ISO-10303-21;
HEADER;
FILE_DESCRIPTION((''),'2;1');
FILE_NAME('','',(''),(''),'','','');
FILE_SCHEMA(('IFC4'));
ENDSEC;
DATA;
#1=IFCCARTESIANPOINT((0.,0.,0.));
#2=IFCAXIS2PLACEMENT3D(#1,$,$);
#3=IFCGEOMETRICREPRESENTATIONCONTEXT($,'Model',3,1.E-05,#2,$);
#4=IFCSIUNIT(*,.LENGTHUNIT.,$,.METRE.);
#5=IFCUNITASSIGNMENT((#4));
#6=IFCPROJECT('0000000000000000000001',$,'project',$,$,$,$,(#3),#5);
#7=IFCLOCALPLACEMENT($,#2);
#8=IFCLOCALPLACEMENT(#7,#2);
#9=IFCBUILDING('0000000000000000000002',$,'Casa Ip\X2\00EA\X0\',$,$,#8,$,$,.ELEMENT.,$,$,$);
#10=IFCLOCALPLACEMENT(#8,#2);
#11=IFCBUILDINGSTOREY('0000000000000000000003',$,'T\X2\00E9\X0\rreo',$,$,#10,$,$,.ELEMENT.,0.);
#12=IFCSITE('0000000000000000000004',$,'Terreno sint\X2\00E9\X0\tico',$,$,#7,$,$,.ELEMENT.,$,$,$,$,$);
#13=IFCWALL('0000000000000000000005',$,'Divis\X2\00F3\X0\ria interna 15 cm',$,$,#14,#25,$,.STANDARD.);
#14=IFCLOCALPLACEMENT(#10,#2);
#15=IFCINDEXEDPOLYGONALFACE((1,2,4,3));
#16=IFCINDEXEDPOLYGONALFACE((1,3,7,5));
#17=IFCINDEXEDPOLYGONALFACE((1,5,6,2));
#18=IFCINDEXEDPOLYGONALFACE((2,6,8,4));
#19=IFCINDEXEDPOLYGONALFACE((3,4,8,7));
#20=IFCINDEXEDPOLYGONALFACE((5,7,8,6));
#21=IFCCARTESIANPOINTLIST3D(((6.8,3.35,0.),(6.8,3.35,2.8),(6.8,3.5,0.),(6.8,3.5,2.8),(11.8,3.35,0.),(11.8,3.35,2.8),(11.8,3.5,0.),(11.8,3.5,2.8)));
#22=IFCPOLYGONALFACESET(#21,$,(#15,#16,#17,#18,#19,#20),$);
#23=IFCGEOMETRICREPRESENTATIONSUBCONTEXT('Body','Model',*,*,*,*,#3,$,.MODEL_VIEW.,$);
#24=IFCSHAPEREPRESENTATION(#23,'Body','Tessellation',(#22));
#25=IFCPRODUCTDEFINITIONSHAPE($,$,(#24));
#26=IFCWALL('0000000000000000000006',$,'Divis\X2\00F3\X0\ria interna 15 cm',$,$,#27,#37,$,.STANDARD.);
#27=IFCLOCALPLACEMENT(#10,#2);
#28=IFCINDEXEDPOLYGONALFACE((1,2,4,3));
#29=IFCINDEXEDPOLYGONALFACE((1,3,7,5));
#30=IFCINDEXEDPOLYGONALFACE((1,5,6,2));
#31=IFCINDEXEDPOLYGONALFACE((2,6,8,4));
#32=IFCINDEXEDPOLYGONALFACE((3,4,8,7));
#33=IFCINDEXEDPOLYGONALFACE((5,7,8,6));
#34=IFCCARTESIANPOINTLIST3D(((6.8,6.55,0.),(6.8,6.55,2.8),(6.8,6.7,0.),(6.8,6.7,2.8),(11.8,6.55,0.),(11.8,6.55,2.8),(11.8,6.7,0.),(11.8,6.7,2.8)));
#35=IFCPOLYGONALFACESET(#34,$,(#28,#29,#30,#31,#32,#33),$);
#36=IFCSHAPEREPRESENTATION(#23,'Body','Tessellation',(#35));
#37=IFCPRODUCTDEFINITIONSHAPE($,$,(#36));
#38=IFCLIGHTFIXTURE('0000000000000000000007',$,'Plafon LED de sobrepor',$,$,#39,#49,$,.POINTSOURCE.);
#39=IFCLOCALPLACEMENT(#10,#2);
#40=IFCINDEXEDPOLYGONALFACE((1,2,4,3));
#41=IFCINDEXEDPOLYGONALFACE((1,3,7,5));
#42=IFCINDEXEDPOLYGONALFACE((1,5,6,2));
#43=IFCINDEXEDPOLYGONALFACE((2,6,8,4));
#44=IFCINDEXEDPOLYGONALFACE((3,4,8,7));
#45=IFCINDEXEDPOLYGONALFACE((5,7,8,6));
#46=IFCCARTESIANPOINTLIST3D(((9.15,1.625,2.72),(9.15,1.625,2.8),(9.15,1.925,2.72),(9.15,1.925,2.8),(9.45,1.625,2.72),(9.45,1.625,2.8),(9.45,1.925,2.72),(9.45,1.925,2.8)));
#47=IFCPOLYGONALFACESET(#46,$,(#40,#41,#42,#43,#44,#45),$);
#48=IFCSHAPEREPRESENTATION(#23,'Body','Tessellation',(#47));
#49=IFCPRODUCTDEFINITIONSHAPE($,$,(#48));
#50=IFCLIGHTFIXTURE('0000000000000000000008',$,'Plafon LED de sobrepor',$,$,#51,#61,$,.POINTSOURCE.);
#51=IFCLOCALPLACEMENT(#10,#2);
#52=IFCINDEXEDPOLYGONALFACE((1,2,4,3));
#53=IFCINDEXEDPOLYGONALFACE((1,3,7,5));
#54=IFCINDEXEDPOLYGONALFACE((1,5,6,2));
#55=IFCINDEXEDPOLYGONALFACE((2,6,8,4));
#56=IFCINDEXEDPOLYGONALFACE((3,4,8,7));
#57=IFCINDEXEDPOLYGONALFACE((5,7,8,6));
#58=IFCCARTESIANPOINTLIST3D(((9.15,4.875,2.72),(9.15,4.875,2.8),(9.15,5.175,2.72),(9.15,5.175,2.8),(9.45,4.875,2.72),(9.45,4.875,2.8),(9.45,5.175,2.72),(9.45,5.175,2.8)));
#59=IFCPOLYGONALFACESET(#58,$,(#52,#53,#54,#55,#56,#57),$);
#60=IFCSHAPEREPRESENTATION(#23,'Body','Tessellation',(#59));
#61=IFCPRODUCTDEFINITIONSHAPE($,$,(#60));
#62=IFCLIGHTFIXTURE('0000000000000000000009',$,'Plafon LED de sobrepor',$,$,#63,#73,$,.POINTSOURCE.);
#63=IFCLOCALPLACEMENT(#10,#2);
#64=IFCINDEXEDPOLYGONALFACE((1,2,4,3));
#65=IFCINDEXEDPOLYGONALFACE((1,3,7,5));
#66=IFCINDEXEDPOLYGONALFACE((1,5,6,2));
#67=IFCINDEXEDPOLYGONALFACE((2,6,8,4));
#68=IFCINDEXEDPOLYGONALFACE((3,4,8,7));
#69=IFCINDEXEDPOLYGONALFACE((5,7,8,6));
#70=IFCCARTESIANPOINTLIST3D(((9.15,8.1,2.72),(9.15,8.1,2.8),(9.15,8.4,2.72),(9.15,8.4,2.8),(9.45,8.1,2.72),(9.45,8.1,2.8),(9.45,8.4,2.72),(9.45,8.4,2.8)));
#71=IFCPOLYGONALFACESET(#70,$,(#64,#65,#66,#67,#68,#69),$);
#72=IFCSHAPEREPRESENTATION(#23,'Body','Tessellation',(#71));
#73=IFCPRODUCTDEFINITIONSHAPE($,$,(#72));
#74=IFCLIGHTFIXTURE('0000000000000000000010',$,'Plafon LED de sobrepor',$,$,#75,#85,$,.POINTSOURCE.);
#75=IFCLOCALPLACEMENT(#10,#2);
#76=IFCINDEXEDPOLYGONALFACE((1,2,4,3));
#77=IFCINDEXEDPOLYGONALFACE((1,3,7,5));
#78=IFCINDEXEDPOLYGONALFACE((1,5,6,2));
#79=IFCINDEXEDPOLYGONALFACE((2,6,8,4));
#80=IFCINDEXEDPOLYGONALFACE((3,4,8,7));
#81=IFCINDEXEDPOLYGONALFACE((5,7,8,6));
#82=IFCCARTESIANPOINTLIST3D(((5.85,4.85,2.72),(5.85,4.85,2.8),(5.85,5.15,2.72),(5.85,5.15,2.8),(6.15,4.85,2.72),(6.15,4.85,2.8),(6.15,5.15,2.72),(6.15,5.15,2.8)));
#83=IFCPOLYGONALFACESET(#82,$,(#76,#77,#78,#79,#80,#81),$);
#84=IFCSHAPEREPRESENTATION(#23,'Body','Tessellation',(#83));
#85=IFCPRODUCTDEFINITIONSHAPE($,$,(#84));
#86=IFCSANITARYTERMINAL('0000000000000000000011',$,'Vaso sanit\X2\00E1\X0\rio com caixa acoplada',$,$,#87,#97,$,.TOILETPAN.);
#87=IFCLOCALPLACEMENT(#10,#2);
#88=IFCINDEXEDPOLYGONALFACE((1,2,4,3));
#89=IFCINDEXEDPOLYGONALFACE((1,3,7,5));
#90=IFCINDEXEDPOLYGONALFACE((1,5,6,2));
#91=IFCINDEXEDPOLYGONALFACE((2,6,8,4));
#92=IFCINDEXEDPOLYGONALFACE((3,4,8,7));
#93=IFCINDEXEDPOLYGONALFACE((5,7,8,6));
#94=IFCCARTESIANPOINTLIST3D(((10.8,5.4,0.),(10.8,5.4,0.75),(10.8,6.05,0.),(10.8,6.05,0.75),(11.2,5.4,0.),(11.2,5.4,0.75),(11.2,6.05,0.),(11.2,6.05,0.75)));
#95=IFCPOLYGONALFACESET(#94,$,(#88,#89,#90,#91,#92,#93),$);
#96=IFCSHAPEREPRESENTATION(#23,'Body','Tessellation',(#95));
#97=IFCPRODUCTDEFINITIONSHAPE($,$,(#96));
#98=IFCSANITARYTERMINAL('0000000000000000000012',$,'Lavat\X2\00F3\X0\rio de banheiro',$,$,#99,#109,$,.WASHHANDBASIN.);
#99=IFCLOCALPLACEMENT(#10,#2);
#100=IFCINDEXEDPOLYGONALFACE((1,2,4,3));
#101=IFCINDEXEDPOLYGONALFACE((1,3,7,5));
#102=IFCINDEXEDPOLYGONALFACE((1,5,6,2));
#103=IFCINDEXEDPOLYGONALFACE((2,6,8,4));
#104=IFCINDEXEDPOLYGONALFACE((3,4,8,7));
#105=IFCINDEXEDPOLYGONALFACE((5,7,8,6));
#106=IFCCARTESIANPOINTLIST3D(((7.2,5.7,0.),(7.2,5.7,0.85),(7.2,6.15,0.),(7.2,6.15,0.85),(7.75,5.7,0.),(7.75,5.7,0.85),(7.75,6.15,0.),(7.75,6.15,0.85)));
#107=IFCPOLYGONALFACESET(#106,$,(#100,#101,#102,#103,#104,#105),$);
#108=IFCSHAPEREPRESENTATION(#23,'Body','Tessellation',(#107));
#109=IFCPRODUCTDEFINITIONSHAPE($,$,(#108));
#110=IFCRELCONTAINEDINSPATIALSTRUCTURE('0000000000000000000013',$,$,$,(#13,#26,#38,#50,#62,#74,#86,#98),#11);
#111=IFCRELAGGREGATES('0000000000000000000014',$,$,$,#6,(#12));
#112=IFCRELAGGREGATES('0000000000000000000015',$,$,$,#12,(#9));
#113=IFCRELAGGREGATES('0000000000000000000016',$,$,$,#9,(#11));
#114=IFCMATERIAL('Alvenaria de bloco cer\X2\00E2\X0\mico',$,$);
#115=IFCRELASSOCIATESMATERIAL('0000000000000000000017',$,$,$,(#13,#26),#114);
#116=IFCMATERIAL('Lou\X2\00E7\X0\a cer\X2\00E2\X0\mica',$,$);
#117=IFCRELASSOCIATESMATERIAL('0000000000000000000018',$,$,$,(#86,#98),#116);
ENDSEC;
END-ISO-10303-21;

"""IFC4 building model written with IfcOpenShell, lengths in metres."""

from ifc_helpers import new_model, si_unit, frame, frame_2d, origin, place, context, subcontext, project, spatial, rectangle, extrude, material, element, save


model = new_model("IFC4")

# Units and contexts
model_context = context("Model", 3, precision=1e-05, world=origin())
body_context = subcontext(model_context, "Body", "Model", "MODEL_VIEW")
ifc_project = project(units=[si_unit("LENGTHUNIT", "METRE")], contexts=[model_context])

# Site, building, storey
site_placement = place(None, origin())
site = spatial("IfcSite", under=ifc_project, at=site_placement, Name="Terreno sintético", CompositionType="ELEMENT")
building_placement = place(site_placement, origin())
building = spatial("IfcBuilding", under=site, at=building_placement, Name="Casa Ipê", CompositionType="ELEMENT")
storey_placement = place(building_placement, origin())
storey = spatial("IfcBuildingStorey", under=building, at=storey_placement, Name="Térreo", CompositionType="ELEMENT", Elevation=0.0)

# Shared definitions
ifc_material_1 = material(Name="Alvenaria de bloco cerâmico")

# Walls
for number, where, name in (
    (1, (6.8, 3.35, 0.0), "Divisória interna 15 cm"),
    (2, (6.8, 6.55, 0.0), "Divisória interna 15 cm"),
):
    element("IfcWall", number, at=place(storey_placement, frame(where)), inside=storey, material=ifc_material_1, Name=name, PredefinedType="STANDARD", context=body_context, shape_type="SweptSolid", body=[
        extrude(rectangle(XDim=5.0, YDim=0.15, at=frame_2d((2.5, 0.075))), origin(), (0.0, 0.0, 1.0), 2.8),
    ])

# Light fixtures
for number, where, name in (
    (3, (9.15, 1.625, 2.72), "Plafon LED de sobrepor"),
    (4, (9.15, 4.875, 2.72), "Plafon LED de sobrepor"),
    (5, (9.15, 8.1, 2.72), "Plafon LED de sobrepor"),
    (6, (5.85, 4.85, 2.72), "Plafon LED de sobrepor"),
):
    element("IfcLightFixture", number, at=place(storey_placement, frame(where)), inside=storey, Name=name, PredefinedType="POINTSOURCE", context=body_context, shape_type="SweptSolid", body=[
        extrude(rectangle(XDim=0.3, YDim=0.3, at=frame_2d((0.15, 0.15))), origin(), (0.0, 0.0, 1.0), 0.08),
    ])

# Sanitary terminals
ifc_material_2 = material(Name="Louça cerâmica")
sanitary_terminal_1_placement = place(storey_placement, frame((10.8, 5.4, 0.0)))
element("IfcSanitaryTerminal", 7, at=sanitary_terminal_1_placement, inside=storey, material=ifc_material_2, Name="Vaso sanitário com caixa acoplada", PredefinedType="TOILETPAN", context=body_context, shape_type="SweptSolid", body=[
    extrude(rectangle(XDim=0.4, YDim=0.65, at=frame_2d((0.2, 0.325))), origin(), (0.0, 0.0, 1.0), 0.75),
])
sanitary_terminal_2_placement = place(storey_placement, frame((7.2, 5.7, 0.0)))
element("IfcSanitaryTerminal", 8, at=sanitary_terminal_2_placement, inside=storey, material=ifc_material_2, Name="Lavatório de banheiro", PredefinedType="WASHHANDBASIN", context=body_context, shape_type="SweptSolid", body=[
    extrude(rectangle(XDim=0.55, YDim=0.45, at=frame_2d((0.275, 0.225))), origin(), (0.0, 0.0, 1.0), 0.85),
])

save(model, "model.ifc")
